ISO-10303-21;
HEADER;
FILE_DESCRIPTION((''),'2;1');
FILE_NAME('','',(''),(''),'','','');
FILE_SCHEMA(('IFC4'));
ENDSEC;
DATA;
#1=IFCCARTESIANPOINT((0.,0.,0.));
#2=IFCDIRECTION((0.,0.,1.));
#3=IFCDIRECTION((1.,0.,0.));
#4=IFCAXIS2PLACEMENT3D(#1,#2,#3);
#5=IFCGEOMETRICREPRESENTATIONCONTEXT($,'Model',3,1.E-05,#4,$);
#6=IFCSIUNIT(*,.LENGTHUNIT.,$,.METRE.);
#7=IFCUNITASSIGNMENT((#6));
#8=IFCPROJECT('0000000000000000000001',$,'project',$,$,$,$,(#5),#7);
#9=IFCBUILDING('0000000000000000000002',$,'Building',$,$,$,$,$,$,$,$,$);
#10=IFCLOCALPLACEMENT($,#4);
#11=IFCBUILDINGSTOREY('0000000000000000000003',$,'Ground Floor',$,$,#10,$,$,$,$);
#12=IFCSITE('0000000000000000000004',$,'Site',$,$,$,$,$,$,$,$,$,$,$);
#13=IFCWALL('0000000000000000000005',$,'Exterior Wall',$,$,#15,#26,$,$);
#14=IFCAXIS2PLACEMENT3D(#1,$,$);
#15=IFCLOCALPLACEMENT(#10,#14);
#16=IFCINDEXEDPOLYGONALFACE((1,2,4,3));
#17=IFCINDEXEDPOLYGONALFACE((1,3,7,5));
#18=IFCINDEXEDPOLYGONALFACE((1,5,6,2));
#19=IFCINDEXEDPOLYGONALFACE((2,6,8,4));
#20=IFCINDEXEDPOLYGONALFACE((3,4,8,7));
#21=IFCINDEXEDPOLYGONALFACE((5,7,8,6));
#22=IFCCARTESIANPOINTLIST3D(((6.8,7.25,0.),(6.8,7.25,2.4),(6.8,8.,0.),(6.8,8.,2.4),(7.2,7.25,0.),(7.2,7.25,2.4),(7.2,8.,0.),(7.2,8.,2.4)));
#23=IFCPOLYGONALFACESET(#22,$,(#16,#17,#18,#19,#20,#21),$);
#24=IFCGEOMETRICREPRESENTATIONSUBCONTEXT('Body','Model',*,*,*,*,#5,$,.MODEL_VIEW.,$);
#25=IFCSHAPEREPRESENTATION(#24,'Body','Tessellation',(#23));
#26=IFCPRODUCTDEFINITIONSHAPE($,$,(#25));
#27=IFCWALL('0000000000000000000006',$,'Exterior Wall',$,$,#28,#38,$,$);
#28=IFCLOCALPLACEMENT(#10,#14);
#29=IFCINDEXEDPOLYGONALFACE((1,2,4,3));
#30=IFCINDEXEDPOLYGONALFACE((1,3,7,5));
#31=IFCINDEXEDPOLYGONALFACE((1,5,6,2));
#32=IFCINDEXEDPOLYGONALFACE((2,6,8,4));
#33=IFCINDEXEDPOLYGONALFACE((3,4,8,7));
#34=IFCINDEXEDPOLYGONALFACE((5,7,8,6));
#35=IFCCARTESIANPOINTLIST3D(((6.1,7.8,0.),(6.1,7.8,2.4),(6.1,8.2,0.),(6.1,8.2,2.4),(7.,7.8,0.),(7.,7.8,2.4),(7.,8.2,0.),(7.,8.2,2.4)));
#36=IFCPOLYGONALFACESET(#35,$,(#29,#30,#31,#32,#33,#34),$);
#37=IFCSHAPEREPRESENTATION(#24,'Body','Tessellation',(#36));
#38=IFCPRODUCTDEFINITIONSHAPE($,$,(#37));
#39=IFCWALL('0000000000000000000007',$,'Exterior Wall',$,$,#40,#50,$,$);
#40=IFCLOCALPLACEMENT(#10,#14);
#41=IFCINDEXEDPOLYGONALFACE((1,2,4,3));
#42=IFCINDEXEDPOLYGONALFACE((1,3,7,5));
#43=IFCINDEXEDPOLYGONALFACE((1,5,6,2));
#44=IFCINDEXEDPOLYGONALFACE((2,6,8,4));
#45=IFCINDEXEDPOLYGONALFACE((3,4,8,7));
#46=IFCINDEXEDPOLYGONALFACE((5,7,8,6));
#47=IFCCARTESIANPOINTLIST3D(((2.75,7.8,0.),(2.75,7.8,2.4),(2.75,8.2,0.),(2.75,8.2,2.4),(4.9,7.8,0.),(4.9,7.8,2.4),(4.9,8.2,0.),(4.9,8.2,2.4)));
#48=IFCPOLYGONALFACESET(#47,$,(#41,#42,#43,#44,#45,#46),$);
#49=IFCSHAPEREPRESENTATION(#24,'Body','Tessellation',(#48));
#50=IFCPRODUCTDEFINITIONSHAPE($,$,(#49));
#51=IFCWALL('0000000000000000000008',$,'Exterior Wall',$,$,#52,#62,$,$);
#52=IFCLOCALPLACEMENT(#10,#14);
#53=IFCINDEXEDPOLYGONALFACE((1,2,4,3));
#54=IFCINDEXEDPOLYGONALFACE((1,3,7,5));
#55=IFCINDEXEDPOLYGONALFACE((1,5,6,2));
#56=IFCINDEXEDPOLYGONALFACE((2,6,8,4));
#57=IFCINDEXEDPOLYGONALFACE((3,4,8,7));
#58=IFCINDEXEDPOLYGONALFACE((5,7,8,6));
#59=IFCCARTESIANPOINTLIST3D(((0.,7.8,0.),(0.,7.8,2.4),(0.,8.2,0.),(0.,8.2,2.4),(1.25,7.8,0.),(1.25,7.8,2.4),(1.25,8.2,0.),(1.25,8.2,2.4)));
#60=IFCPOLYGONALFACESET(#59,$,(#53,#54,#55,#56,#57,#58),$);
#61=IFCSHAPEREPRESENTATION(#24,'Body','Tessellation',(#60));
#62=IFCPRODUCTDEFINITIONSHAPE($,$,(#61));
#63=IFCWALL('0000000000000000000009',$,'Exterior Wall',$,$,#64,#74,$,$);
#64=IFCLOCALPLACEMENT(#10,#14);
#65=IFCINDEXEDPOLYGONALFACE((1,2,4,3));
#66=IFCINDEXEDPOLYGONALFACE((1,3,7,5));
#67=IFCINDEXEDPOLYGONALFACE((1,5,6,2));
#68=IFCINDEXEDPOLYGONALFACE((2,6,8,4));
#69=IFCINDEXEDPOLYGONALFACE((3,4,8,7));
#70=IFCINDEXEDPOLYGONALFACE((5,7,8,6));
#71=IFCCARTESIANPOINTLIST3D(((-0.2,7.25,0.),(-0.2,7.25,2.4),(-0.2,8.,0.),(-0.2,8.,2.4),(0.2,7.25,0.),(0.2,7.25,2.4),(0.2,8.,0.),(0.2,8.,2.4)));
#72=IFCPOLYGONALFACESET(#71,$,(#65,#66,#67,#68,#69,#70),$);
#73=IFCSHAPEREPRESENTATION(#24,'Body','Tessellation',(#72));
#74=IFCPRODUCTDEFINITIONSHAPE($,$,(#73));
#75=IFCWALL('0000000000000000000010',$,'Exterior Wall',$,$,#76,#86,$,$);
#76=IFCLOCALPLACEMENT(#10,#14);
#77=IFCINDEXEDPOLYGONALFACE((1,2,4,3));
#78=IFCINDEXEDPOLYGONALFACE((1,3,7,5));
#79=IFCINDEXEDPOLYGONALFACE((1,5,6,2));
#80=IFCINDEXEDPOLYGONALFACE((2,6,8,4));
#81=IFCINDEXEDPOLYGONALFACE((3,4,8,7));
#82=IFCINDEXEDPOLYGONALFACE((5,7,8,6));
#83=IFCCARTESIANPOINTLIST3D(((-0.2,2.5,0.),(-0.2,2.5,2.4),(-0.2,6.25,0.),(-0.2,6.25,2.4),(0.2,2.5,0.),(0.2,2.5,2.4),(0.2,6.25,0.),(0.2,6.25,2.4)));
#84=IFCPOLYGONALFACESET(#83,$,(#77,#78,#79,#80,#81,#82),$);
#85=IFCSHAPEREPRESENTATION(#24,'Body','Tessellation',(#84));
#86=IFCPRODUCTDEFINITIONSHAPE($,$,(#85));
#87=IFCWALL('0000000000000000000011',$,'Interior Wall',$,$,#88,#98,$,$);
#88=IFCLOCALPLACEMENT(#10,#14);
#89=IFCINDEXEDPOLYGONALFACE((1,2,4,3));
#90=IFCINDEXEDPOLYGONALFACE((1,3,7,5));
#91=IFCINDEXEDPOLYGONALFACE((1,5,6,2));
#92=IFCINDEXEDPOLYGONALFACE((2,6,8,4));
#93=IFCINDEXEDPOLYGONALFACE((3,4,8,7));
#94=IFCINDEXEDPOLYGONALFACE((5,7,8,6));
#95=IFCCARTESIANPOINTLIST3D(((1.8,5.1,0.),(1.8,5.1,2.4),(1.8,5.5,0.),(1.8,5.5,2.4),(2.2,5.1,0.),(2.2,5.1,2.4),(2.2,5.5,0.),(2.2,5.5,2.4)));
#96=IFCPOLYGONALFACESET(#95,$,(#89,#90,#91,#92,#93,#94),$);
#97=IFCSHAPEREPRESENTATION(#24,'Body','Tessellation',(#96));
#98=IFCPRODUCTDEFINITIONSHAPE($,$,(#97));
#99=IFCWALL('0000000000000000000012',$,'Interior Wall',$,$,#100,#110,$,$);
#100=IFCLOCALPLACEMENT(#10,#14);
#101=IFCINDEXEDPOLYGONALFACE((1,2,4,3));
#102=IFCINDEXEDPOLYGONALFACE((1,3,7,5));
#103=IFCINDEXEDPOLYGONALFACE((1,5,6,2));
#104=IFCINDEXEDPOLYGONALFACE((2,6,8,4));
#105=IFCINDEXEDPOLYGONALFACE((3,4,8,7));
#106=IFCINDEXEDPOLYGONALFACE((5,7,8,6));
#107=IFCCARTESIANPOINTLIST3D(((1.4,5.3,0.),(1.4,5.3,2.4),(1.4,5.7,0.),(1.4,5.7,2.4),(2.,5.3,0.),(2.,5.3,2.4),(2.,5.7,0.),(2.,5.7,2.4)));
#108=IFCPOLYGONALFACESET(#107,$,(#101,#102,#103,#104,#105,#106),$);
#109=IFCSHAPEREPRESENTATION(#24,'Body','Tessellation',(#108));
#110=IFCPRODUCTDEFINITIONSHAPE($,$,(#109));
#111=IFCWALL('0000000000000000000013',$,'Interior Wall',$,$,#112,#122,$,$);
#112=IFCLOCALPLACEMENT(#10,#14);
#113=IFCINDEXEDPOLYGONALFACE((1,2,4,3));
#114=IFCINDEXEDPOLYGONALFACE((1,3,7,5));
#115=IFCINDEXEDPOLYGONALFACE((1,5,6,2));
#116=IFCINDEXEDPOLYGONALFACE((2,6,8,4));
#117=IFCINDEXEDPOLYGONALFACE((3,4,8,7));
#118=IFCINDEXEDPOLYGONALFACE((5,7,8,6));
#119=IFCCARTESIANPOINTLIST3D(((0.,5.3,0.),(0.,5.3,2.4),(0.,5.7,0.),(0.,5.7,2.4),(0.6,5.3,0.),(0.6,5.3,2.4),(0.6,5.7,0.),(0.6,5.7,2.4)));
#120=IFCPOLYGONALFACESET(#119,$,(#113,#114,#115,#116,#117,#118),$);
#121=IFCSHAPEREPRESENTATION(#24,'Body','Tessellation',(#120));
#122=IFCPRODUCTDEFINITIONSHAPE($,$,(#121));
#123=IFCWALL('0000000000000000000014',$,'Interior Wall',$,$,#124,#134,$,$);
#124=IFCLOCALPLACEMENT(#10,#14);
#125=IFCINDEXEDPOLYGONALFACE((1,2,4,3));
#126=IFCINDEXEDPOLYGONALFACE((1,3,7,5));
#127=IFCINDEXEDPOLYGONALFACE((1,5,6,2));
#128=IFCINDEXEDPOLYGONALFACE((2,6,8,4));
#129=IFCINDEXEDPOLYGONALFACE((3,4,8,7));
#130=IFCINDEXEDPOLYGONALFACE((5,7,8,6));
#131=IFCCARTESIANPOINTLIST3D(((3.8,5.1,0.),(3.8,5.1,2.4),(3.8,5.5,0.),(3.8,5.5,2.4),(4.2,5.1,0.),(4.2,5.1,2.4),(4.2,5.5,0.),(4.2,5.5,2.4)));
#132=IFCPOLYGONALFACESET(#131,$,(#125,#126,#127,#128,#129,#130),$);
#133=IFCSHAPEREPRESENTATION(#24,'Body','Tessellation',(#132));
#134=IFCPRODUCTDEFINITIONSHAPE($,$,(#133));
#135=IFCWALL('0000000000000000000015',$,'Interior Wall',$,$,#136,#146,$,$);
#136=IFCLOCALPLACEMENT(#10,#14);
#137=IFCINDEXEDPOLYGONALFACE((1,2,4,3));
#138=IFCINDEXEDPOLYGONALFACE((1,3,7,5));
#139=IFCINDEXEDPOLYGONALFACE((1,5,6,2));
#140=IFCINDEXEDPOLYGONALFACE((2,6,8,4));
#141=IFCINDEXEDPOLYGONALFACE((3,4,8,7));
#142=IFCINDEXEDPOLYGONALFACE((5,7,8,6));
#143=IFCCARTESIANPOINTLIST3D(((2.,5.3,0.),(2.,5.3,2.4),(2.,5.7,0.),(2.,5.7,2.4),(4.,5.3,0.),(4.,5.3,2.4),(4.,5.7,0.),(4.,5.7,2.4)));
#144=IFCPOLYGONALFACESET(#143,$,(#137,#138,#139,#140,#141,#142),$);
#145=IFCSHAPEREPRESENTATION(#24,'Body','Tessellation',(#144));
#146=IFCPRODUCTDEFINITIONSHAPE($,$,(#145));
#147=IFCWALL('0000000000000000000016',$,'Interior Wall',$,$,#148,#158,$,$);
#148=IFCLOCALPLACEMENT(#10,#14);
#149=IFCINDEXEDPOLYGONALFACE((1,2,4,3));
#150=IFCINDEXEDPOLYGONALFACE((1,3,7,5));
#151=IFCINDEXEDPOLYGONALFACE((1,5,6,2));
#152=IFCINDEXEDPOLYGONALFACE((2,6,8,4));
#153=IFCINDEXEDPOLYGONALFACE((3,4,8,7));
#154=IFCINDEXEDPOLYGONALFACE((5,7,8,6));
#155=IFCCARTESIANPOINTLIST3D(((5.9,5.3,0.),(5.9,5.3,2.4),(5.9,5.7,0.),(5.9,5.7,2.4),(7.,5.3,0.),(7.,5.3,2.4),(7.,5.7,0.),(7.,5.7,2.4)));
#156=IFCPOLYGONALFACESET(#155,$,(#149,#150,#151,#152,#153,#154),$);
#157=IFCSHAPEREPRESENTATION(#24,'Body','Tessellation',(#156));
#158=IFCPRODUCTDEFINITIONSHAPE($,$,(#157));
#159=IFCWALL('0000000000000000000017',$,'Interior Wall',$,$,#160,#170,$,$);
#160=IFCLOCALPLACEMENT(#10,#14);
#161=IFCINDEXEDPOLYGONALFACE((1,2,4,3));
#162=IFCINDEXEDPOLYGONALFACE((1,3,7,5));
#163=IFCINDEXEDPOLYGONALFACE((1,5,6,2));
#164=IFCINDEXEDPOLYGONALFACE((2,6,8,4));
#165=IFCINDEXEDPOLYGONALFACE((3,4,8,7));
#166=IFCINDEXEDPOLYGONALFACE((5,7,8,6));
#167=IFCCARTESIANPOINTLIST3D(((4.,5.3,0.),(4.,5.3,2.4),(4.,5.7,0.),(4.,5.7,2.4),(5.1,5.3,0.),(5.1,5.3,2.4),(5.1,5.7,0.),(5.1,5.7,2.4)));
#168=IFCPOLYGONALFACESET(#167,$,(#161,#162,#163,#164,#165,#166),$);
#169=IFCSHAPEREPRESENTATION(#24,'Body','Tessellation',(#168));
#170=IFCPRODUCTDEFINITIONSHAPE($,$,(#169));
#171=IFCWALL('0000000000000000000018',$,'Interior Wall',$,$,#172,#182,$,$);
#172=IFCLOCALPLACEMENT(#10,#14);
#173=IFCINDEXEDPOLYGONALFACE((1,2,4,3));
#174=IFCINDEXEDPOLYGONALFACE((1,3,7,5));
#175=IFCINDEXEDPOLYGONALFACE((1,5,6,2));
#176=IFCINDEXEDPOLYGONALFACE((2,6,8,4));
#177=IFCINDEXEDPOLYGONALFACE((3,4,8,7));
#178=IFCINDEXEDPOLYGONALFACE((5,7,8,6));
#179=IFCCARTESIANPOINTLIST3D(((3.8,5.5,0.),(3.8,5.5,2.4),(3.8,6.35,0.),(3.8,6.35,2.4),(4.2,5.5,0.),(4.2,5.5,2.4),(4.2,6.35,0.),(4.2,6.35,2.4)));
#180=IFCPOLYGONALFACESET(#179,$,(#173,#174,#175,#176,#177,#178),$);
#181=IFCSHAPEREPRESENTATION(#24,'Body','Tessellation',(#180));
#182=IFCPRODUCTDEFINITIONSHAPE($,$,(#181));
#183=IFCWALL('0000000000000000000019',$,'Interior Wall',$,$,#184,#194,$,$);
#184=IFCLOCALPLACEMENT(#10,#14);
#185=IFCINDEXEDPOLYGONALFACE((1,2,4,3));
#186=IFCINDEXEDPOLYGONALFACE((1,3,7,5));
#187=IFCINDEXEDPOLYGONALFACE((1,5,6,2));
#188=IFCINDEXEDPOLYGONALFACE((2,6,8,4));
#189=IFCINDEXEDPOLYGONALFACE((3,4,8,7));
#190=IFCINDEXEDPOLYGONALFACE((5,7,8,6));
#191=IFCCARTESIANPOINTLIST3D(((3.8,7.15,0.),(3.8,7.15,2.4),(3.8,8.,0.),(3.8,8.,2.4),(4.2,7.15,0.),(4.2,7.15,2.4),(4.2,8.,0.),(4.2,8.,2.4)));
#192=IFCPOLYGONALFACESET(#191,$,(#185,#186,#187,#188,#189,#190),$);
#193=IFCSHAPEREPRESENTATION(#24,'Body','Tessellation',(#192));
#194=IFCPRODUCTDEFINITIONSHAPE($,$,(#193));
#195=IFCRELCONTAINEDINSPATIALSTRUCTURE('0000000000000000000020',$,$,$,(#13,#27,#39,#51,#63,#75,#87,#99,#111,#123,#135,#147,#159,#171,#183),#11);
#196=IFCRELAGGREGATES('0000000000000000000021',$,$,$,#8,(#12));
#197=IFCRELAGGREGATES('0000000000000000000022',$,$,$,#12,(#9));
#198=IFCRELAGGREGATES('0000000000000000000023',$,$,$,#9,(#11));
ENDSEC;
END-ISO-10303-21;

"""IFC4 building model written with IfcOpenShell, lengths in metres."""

from ifc_helpers import new_model, si_unit, frame, origin_with_axes, place, context, subcontext, project, spatial, indexed_curve, outline, extrude, element, save


model = new_model("IFC4")

# Units and contexts
model_context = context("Model", 3, precision=1e-05, world=origin_with_axes())
body_context = subcontext(model_context, "Body", "Model", "MODEL_VIEW")
ifc_project = project(units=[si_unit("LENGTHUNIT", "METRE")], contexts=[model_context])

# Site, building, storey
site = spatial("IfcSite", under=ifc_project, Name="Site")
building = spatial("IfcBuilding", under=site, Name="Building")
storey_placement = place(None, origin_with_axes())
storey = spatial("IfcBuildingStorey", under=building, at=storey_placement, Name="Ground Floor")

# Walls
wall_1_placement = place(storey_placement, frame((7.0, 7.25, 0.0), z_axis=(0.0, 0.0, 1.0), x_axis=(0.0, 1.0, 0.0)))
element("IfcWall", 1, at=wall_1_placement, inside=storey, Name="Exterior Wall", context=body_context, shape_type="SweptSolid", body=[
    extrude(outline(indexed_curve([(0.0, 0.0), (0.0, 0.4), (0.75, 0.4), (0.75, 0.0), (0.0, 0.0)], self_intersect=False)), frame((0.0, -0.2, 0.0), z_axis=(0.0, 0.0, 1.0), x_axis=(1.0, 0.0, 0.0)), (0.0, 0.0, 1.0), 2.4),
])
wall_2_placement = place(storey_placement, frame((7.0, 8.0, 0.0), z_axis=(0.0, 0.0, 1.0), x_axis=(-1.0, 0.0, 0.0)))
element("IfcWall", 2, at=wall_2_placement, inside=storey, Name="Exterior Wall", context=body_context, shape_type="SweptSolid", body=[
    extrude(outline(indexed_curve([(0.0, 0.0), (0.0, 0.4), (0.9, 0.4), (0.9, 0.0), (0.0, 0.0)], self_intersect=False)), frame((0.0, -0.2, 0.0), z_axis=(0.0, 0.0, 1.0), x_axis=(1.0, 0.0, 0.0)), (0.0, 0.0, 1.0), 2.4),
])
wall_3_placement = place(storey_placement, frame((4.9, 8.0, 0.0), z_axis=(0.0, 0.0, 1.0), x_axis=(-1.0, 0.0, 0.0)))
element("IfcWall", 3, at=wall_3_placement, inside=storey, Name="Exterior Wall", context=body_context, shape_type="SweptSolid", body=[
    extrude(outline(indexed_curve([(0.0, 0.0), (0.0, 0.4), (2.15, 0.4), (2.15, 0.0), (0.0, 0.0)], self_intersect=False)), frame((0.0, -0.2, 0.0), z_axis=(0.0, 0.0, 1.0), x_axis=(1.0, 0.0, 0.0)), (0.0, 0.0, 1.0), 2.4),
])
wall_4_placement = place(storey_placement, frame((1.25, 8.0, 0.0), z_axis=(0.0, 0.0, 1.0), x_axis=(-1.0, 0.0, 0.0)))
element("IfcWall", 4, at=wall_4_placement, inside=storey, Name="Exterior Wall", context=body_context, shape_type="SweptSolid", body=[
    extrude(outline(indexed_curve([(0.0, 0.0), (0.0, 0.4), (1.25, 0.4), (1.25, 0.0), (0.0, 0.0)], self_intersect=False)), frame((0.0, -0.2, 0.0), z_axis=(0.0, 0.0, 1.0), x_axis=(1.0, 0.0, 0.0)), (0.0, 0.0, 1.0), 2.4),
])
wall_5_placement = place(storey_placement, frame((0.0, 8.0, 0.0), z_axis=(0.0, 0.0, 1.0), x_axis=(0.0, -1.0, 0.0)))
element("IfcWall", 5, at=wall_5_placement, inside=storey, Name="Exterior Wall", context=body_context, shape_type="SweptSolid", body=[
    extrude(outline(indexed_curve([(0.0, 0.0), (0.0, 0.4), (0.75, 0.4), (0.75, 0.0), (0.0, 0.0)], self_intersect=False)), frame((0.0, -0.2, 0.0), z_axis=(0.0, 0.0, 1.0), x_axis=(1.0, 0.0, 0.0)), (0.0, 0.0, 1.0), 2.4),
])
wall_6_placement = place(storey_placement, frame((0.0, 6.25, 0.0), z_axis=(0.0, 0.0, 1.0), x_axis=(0.0, -1.0, 0.0)))
element("IfcWall", 6, at=wall_6_placement, inside=storey, Name="Exterior Wall", context=body_context, shape_type="SweptSolid", body=[
    extrude(outline(indexed_curve([(0.0, 0.0), (0.0, 0.4), (3.75, 0.4), (3.75, 0.0), (0.0, 0.0)], self_intersect=False)), frame((0.0, -0.2, 0.0), z_axis=(0.0, 0.0, 1.0), x_axis=(1.0, 0.0, 0.0)), (0.0, 0.0, 1.0), 2.4),
])
wall_7_placement = place(storey_placement, frame((2.0, 5.1, 0.0), z_axis=(0.0, 0.0, 1.0), x_axis=(0.0, 1.0, 0.0)))
element("IfcWall", 7, at=wall_7_placement, inside=storey, Name="Interior Wall", context=body_context, shape_type="SweptSolid", body=[
    extrude(outline(indexed_curve([(0.0, 0.0), (0.0, 0.4), (0.4, 0.4), (0.4, 0.0), (0.0, 0.0)], self_intersect=False)), frame((0.0, -0.2, 0.0), z_axis=(0.0, 0.0, 1.0), x_axis=(1.0, 0.0, 0.0)), (0.0, 0.0, 1.0), 2.4),
])
for number, where, z_axis, x_axis, name in (
    (8, (2.0, 5.5, 0.0), (0.0, 0.0, 1.0), (-1.0, 0.0, 0.0), "Interior Wall"),
    (9, (0.6, 5.5, 0.0), (0.0, 0.0, 1.0), (-1.0, 0.0, 0.0), "Interior Wall"),
):
    element("IfcWall", number, at=place(storey_placement, frame(where, z_axis=z_axis, x_axis=x_axis)), inside=storey, Name=name, context=body_context, shape_type="SweptSolid", body=[
        extrude(outline(indexed_curve([(0.0, 0.0), (0.0, 0.4), (0.6, 0.4), (0.6, 0.0), (0.0, 0.0)], self_intersect=False)), frame((0.0, -0.2, 0.0), z_axis=(0.0, 0.0, 1.0), x_axis=(1.0, 0.0, 0.0)), (0.0, 0.0, 1.0), 2.4),
    ])
wall_8_placement = place(storey_placement, frame((4.0, 5.1, 0.0), z_axis=(0.0, 0.0, 1.0), x_axis=(0.0, 1.0, 0.0)))
element("IfcWall", 10, at=wall_8_placement, inside=storey, Name="Interior Wall", context=body_context, shape_type="SweptSolid", body=[
    extrude(outline(indexed_curve([(0.0, 0.0), (0.0, 0.4), (0.4, 0.4), (0.4, 0.0), (0.0, 0.0)], self_intersect=False)), frame((0.0, -0.2, 0.0), z_axis=(0.0, 0.0, 1.0), x_axis=(1.0, 0.0, 0.0)), (0.0, 0.0, 1.0), 2.4),
])
wall_9_placement = place(storey_placement, frame((4.0, 5.5, 0.0), z_axis=(0.0, 0.0, 1.0), x_axis=(-1.0, 0.0, 0.0)))
element("IfcWall", 11, at=wall_9_placement, inside=storey, Name="Interior Wall", context=body_context, shape_type="SweptSolid", body=[
    extrude(outline(indexed_curve([(0.0, 0.0), (0.0, 0.4), (2.0, 0.4), (2.0, 0.0), (0.0, 0.0)], self_intersect=False)), frame((0.0, -0.2, 0.0), z_axis=(0.0, 0.0, 1.0), x_axis=(1.0, 0.0, 0.0)), (0.0, 0.0, 1.0), 2.4),
])
for number, where, z_axis, x_axis, name in (
    (12, (7.0, 5.5, 0.0), (0.0, 0.0, 1.0), (-1.0, 0.0, 0.0), "Interior Wall"),
    (13, (5.1, 5.5, 0.0), (0.0, 0.0, 1.0), (-1.0, 0.0, 0.0), "Interior Wall"),
):
    element("IfcWall", number, at=place(storey_placement, frame(where, z_axis=z_axis, x_axis=x_axis)), inside=storey, Name=name, context=body_context, shape_type="SweptSolid", body=[
        extrude(outline(indexed_curve([(0.0, 0.0), (0.0, 0.4), (1.1, 0.4), (1.1, 0.0), (0.0, 0.0)], self_intersect=False)), frame((0.0, -0.2, 0.0), z_axis=(0.0, 0.0, 1.0), x_axis=(1.0, 0.0, 0.0)), (0.0, 0.0, 1.0), 2.4),
    ])
for number, where, z_axis, x_axis, name in (
    (14, (4.0, 5.5, 0.0), (0.0, 0.0, 1.0), (0.0, 1.0, 0.0), "Interior Wall"),
    (15, (4.0, 7.15, 0.0), (0.0, 0.0, 1.0), (0.0, 1.0, 0.0), "Interior Wall"),
):
    element("IfcWall", number, at=place(storey_placement, frame(where, z_axis=z_axis, x_axis=x_axis)), inside=storey, Name=name, context=body_context, shape_type="SweptSolid", body=[
        extrude(outline(indexed_curve([(0.0, 0.0), (0.0, 0.4), (0.85, 0.4), (0.85, 0.0), (0.0, 0.0)], self_intersect=False)), frame((0.0, -0.2, 0.0), z_axis=(0.0, 0.0, 1.0), x_axis=(1.0, 0.0, 0.0)), (0.0, 0.0, 1.0), 2.4),
    ])

save(model, "model.ifc")
